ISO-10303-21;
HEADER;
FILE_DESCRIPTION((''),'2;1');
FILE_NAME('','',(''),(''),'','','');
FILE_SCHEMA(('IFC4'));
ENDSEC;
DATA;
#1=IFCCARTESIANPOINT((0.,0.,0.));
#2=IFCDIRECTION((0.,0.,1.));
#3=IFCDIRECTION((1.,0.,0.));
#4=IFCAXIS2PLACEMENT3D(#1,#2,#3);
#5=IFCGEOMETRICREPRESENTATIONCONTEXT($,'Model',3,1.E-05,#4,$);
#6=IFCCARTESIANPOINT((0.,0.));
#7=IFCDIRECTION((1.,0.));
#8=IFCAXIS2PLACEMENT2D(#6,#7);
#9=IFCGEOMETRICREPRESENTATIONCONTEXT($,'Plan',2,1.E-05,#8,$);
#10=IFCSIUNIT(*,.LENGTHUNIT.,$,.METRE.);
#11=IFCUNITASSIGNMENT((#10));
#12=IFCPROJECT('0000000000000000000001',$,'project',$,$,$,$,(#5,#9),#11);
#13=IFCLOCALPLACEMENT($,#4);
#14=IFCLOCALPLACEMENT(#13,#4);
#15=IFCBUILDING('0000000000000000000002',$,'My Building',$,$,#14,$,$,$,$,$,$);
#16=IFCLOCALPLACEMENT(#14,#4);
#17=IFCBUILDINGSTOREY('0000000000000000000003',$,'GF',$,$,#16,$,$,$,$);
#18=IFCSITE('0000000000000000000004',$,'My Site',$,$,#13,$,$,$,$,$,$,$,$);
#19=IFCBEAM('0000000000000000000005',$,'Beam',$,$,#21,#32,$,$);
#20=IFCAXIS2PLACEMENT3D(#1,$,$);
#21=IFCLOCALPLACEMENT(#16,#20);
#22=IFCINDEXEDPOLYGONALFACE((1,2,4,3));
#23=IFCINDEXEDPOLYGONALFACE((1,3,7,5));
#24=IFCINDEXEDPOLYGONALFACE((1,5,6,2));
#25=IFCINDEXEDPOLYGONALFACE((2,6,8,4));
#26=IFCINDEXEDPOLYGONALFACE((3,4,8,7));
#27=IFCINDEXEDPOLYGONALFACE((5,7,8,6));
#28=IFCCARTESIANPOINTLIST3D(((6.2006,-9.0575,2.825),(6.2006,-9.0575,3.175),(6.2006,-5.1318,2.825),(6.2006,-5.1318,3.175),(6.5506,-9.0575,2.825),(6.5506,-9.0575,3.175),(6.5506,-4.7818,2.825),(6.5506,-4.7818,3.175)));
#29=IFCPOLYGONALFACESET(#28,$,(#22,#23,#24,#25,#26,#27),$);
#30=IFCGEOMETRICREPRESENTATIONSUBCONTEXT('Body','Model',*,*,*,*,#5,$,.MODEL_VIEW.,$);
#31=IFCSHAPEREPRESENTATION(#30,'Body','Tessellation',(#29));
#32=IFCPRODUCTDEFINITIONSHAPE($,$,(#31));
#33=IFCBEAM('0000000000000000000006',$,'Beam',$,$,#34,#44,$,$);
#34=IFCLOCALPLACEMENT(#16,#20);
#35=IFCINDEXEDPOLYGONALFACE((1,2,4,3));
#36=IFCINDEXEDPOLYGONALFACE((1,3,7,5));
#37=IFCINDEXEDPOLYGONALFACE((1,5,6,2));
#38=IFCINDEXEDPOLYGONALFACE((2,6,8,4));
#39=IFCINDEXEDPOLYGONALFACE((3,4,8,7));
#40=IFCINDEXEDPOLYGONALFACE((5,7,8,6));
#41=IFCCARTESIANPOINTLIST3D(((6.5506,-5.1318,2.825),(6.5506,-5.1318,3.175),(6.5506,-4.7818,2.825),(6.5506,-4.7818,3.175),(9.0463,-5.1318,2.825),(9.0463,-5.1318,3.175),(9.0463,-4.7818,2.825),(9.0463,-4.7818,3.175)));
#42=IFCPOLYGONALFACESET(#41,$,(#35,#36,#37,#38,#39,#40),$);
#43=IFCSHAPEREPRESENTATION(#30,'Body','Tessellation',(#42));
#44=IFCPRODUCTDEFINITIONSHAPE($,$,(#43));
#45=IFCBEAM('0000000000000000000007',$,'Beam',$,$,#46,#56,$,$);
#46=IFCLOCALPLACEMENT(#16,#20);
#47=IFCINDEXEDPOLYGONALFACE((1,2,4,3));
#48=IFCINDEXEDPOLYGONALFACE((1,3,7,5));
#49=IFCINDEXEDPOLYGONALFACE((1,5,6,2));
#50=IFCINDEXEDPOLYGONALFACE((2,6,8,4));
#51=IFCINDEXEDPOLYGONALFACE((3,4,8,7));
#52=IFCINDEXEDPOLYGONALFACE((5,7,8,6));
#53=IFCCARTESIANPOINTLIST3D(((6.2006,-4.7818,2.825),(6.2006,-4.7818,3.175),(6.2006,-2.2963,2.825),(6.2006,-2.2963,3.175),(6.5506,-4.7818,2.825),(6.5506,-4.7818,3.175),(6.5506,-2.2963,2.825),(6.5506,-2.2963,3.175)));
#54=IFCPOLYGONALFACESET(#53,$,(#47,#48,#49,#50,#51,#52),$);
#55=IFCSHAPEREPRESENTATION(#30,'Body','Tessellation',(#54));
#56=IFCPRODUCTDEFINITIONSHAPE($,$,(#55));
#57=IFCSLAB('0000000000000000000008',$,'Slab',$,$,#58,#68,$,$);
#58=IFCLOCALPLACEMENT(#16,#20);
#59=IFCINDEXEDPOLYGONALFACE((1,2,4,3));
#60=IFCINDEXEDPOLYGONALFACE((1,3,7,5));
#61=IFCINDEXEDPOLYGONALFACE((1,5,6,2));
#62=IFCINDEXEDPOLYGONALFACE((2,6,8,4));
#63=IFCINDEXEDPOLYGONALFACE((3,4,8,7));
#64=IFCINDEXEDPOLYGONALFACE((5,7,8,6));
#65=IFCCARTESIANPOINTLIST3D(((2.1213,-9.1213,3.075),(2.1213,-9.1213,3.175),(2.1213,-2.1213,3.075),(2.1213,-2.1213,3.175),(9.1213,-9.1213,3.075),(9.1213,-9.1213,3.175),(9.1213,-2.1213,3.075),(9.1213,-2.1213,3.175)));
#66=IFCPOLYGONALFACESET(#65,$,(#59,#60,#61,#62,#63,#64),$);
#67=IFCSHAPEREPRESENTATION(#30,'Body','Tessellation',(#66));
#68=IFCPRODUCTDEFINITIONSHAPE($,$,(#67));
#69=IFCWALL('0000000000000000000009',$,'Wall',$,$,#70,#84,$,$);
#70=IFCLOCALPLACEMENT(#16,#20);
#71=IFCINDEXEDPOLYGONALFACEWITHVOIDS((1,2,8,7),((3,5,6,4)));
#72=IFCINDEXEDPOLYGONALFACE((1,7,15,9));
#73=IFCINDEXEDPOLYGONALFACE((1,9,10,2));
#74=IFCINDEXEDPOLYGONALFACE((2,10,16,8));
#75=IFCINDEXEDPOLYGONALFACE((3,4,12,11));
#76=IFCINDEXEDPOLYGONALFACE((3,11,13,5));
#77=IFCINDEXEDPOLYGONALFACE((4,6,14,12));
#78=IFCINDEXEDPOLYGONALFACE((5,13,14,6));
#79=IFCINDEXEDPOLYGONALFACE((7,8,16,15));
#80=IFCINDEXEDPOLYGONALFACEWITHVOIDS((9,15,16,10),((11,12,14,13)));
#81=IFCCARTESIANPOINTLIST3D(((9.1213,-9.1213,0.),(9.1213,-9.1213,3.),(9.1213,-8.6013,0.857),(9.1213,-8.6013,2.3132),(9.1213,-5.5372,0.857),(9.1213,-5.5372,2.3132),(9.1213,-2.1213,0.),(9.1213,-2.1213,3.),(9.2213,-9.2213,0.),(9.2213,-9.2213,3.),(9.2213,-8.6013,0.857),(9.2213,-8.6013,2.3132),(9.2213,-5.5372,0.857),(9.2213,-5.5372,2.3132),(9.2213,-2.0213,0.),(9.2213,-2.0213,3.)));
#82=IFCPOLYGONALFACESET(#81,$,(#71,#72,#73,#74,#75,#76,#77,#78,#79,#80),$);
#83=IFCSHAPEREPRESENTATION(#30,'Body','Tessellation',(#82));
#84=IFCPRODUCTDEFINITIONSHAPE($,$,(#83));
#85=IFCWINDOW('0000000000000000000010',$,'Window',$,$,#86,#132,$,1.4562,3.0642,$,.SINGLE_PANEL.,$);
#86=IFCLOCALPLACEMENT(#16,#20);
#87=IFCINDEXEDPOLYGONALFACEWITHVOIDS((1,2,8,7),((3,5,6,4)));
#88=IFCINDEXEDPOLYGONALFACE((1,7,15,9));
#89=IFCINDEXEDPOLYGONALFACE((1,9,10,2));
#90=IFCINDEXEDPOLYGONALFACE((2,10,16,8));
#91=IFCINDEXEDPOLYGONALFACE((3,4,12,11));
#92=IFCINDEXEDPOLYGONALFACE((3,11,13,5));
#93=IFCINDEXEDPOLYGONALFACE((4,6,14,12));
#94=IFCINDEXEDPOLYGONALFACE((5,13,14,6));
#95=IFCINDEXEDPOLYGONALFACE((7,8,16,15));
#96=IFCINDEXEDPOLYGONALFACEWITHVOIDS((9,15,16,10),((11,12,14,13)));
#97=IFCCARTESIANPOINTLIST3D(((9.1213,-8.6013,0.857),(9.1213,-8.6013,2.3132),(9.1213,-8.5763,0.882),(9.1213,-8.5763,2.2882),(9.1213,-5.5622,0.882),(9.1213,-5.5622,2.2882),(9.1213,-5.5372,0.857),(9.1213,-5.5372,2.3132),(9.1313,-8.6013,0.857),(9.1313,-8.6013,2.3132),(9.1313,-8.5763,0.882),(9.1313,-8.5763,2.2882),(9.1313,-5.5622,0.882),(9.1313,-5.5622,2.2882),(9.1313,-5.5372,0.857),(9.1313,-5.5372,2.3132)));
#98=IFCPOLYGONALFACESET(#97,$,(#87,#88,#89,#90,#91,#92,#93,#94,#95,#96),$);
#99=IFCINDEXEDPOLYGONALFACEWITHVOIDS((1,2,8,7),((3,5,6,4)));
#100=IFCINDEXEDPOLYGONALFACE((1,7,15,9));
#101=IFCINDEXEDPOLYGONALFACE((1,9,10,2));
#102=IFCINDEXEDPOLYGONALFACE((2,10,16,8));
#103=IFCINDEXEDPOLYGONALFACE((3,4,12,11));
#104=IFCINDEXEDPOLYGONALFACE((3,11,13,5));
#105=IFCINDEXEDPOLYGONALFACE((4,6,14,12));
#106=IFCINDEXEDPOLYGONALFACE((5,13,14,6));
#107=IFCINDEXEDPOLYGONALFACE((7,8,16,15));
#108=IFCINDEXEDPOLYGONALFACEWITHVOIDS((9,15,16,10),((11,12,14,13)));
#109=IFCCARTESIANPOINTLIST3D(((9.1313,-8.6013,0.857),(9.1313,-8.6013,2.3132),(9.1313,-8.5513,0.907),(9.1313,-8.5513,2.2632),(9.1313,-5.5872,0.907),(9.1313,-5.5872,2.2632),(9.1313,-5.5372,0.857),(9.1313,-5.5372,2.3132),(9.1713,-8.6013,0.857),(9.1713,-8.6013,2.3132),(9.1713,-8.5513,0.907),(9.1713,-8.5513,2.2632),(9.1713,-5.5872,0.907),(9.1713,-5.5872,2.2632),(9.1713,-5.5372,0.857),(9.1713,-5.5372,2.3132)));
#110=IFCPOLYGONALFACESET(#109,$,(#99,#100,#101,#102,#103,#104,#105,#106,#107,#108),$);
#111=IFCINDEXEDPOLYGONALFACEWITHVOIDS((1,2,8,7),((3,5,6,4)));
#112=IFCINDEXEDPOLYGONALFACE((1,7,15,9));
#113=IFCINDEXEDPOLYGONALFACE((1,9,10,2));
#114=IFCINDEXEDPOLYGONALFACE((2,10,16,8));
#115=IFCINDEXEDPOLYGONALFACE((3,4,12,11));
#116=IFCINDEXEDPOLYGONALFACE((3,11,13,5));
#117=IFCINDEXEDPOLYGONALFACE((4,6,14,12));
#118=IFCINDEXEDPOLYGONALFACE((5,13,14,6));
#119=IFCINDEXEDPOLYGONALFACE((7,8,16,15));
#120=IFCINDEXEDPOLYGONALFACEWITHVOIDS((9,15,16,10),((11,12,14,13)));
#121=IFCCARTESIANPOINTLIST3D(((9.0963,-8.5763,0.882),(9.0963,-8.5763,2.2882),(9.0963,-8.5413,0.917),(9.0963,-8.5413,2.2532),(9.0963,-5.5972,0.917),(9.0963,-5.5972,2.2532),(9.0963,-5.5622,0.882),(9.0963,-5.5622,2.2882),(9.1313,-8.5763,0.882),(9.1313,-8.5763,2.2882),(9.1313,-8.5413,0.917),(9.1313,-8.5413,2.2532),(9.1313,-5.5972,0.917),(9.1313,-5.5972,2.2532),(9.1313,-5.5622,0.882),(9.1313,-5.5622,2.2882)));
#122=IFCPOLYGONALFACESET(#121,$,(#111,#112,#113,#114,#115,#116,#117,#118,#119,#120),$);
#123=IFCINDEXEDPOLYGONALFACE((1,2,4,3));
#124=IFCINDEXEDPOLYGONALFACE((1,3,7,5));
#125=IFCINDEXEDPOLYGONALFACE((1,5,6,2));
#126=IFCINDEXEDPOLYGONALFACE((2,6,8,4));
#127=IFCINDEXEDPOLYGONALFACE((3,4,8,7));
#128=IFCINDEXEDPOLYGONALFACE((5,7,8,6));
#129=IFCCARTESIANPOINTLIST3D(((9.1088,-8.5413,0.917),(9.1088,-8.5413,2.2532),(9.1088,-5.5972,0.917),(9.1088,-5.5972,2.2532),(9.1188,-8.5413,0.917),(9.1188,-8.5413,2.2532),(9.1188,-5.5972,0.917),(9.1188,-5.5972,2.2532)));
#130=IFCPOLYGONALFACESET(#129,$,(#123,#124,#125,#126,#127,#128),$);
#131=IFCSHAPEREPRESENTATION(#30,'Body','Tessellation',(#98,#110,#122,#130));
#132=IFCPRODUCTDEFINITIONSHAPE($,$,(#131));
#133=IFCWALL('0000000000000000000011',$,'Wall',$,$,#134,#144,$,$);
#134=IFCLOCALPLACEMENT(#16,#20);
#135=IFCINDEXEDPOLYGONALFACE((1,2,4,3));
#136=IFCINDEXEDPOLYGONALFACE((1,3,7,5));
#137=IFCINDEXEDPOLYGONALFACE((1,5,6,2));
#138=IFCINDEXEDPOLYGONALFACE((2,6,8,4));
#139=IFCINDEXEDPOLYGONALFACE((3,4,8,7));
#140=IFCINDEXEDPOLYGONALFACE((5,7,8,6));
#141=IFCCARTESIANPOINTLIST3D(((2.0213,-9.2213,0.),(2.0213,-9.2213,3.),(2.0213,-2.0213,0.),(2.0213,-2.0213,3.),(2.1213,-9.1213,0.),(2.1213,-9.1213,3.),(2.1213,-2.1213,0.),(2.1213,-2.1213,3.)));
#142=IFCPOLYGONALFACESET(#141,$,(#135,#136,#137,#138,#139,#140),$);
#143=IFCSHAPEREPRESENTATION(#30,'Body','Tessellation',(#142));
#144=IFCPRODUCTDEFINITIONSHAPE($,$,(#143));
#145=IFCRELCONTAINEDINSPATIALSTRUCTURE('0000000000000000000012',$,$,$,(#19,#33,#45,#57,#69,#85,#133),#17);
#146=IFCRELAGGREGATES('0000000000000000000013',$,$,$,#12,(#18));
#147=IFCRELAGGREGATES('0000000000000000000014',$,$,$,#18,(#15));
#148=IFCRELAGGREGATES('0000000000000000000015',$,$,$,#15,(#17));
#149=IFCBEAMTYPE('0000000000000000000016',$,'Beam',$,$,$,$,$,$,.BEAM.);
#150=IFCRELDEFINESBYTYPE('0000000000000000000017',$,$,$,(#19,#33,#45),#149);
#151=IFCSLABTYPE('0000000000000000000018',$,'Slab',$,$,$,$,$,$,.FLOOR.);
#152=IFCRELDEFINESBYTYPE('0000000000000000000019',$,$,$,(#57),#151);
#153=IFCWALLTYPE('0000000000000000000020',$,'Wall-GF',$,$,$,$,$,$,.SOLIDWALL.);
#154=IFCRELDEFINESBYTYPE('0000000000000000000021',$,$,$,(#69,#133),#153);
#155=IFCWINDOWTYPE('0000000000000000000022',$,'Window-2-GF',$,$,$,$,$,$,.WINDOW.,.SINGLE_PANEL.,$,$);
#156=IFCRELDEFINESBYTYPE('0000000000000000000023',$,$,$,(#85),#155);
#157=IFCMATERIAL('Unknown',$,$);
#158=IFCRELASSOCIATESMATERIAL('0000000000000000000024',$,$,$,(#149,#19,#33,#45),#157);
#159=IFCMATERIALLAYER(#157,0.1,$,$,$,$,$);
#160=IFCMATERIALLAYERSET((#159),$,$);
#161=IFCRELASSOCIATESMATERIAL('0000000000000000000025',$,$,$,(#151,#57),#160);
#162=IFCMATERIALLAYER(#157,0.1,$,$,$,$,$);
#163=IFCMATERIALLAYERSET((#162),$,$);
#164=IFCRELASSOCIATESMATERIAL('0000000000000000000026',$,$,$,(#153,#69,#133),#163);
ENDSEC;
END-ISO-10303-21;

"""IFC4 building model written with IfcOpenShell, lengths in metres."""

from ifc_helpers import new_model, entity, si_unit, frame, origin_with_axes, origin_2d_with_axis, place, context, subcontext, project, spatial, line, indexed_curve, rectangle, outline, extrude, clip, halfspace, shape, source, transform, mapped, material, layer, layer_set, layer_usage, material_profile, profile_set, profile_usage, type_object, type_shapes, element, fill, save


model = new_model("IFC4")

# Units and contexts
model_context = context("Model", 3, precision=1e-05, world=origin_with_axes())
plan_context = context("Plan", 2, precision=1e-05, world=origin_2d_with_axis())
body_context_1 = subcontext(model_context, "Body", "Model", "MODEL_VIEW")
body_context_2 = subcontext(plan_context, "Body", "Plan", "PLAN_VIEW")
ifc_project = project(units=[si_unit("LENGTHUNIT", "METRE")], contexts=[model_context, plan_context])

# Site, building, storey
site_placement = place(None, origin_with_axes())
site = spatial("IfcSite", under=ifc_project, at=site_placement, Name="My Site")
building_placement = place(site_placement, origin_with_axes())
building = spatial("IfcBuilding", under=site, at=building_placement, Name="My Building")
storey_placement = place(building_placement, origin_with_axes())
storey = spatial("IfcBuildingStorey", under=building, at=storey_placement, Name="GF")

# Shared definitions
ifc_material = material(Name="Unknown")

# Beams
ifc_material_profile_1 = material_profile(ifc_material, rectangle(XDim=0.35, YDim=0.35))
ifc_profile_set_1 = profile_set([ifc_material_profile_1])
beam_type = type_object("IfcBeamType", Name="Beam", PredefinedType="BEAM", material=ifc_profile_set_1)
ifc_profile_usage_1 = profile_usage(ifc_profile_set_1, cardinal=5)
beam_1_placement = place(storey_placement, frame((6.3756, -4.7818, 3.0), z_axis=(0.0, -1.0, 0.0), x_axis=(1.0, 0.0, 0.0)))
element("IfcBeam", 1, at=beam_1_placement, inside=storey, type_object=beam_type, material=ifc_profile_usage_1, Name="Beam", context=body_context_1, shape_type="Clipping", body=[
    clip(extrude(rectangle(XDim=0.35, YDim=0.35), origin_with_axes(), (0.0, 0.0, 1.0), 4.2757), halfspace(frame((0.175, -3.0, 0.0), z_axis=(-0.707107, 0.0, -0.707107), x_axis=(0.0, 1.0, 0.0)), False)),
])
ifc_profile_usage_2 = profile_usage(ifc_profile_set_1, cardinal=5)
beam_2_placement = place(storey_placement, frame((6.5506, -4.9568, 3.0), z_axis=(1.0, 0.0, 0.0), x_axis=(0.0, 1.0, 0.0)))
element("IfcBeam", 2, at=beam_2_placement, inside=storey, type_object=beam_type, material=ifc_profile_usage_2, Name="Beam", context=body_context_1, shape_type="SweptSolid", body=[
    extrude(rectangle(XDim=0.35, YDim=0.35), origin_with_axes(), (0.0, 0.0, 1.0), 2.4957),
])
ifc_profile_usage_3 = profile_usage(ifc_profile_set_1, cardinal=5)
beam_3_placement = place(storey_placement, frame((6.3756, -4.7818, 3.0), z_axis=(0.0, 1.0, 0.0), x_axis=(-1.0, 0.0, 0.0)))
element("IfcBeam", 3, at=beam_3_placement, inside=storey, type_object=beam_type, material=ifc_profile_usage_3, Name="Beam", context=body_context_1, shape_type="SweptSolid", body=[
    extrude(rectangle(XDim=0.35, YDim=0.35), origin_with_axes(), (0.0, 0.0, 1.0), 2.4855),
])

# Slab
ifc_layer_1 = layer(ifc_material, 0.1)
ifc_layer_set_1 = layer_set([ifc_layer_1])
slab_type = type_object("IfcSlabType", Name="Slab", PredefinedType="FLOOR", material=ifc_layer_set_1)
ifc_layer_usage_1 = layer_usage(ifc_layer_set_1, "AXIS3", "POSITIVE", -0.1)
slab_1_placement = place(storey_placement, frame((2.1213, -2.1213, 3.175), z_axis=(0.0, 0.0, 1.0), x_axis=(1.0, 0.0, 0.0)))
element("IfcSlab", 4, at=slab_1_placement, inside=storey, type_object=slab_type, material=ifc_layer_usage_1, Name="Slab", context=body_context_1, shape_type="SweptSolid", body=[
    extrude(outline(indexed_curve([(0.0, 0.0), (7.0, 0.0), (7.0, -7.0), (0.0, -7.0), (0.0, 0.0)])), frame((0.0, 0.0, -0.1), z_axis=(0.0, 0.0, 1.0), x_axis=(1.0, 0.0, 0.0)), (0.0, 0.0, 1.0), 0.1),
])

# Wall, opening, window
ifc_layer_2 = layer(ifc_material, 0.1)
ifc_layer_set_2 = layer_set([ifc_layer_2])
ifc_layer_usage_2 = layer_usage(ifc_layer_set_2, "AXIS2", "POSITIVE", 0.0)
wall_type = type_object("IfcWallType", Name="Wall-GF", PredefinedType="SOLIDWALL", material=ifc_layer_set_2)
wall_1_placement = place(storey_placement, frame((9.1213, -2.1213, 0.0), z_axis=(0.0, 0.0, 1.0), x_axis=(0.0, -1.0, 0.0)))
wall_1 = element("IfcWall", 5, at=wall_1_placement, inside=storey, type_object=wall_type, material=ifc_layer_usage_2, Name="Wall", context=body_context_1, shape_type="SweptSolid", body=[
    extrude(outline(indexed_curve([(0.0, 0.0), (-0.1, 0.1), (7.1, 0.1), (7.0, 0.0)], segments=[line(1, 2, 3, 4, 1)])), origin_with_axes(), (0.0, 0.0, 1.0), 3.0),
])
shared_shape_1 = source(origin_with_axes(), body_context_1, "Body", "SweptSolid", [
    extrude(outline(indexed_curve([(0.0, 0.0), (3.0642, 0.0), (3.0642, 1.4562), (0.0, 1.4562)], segments=[line(1, 2, 3, 4, 1)])), frame((0.0, -0.6, 0.0), z_axis=(0.0, -1.0, 0.0), x_axis=(1.0, 0.0, 0.0)), (0.0, 0.0, -1.0), 1.2),
])
opening_1_placement = place(wall_1_placement, frame((6.48, 0.1, 0.857), z_axis=(0.0, 0.0, 1.0), x_axis=(-1.0, 0.0, 0.0)))
opening_1 = element("IfcOpeningElement", 6, at=opening_1_placement, cuts=wall_1, PredefinedType="OPENING", context=body_context_1, shape_type="MappedRepresentation", body=[
    mapped(shared_shape_1, transform((0.0, 0.0, 0.0), x_axis=(1.0, 0.0, 0.0), y_axis=(0.0, 1.0, 0.0), z_axis=(0.0, 0.0, 1.0), scale=1.0)),
])
window_type_1 = type_object("IfcWindowType", Name="Window-2-GF", PartitioningType="SINGLE_PANEL", PredefinedType="WINDOW")
shared_shape_2 = source(origin_with_axes(), body_context_1, "Body", "SweptSolid", [
    extrude(outline(indexed_curve([(0.0, 0.0), (3.0642, 0.0), (3.0642, 1.4562), (0.0, 1.4562)], segments=[line(1, 2, 3, 4, 1)]), holes=[indexed_curve([(0.025, 0.025), (3.0392, 0.025), (3.0392, 1.4312), (0.025, 1.4312)], segments=[line(1, 2, 3, 4, 1)])]), frame((0.0, 0.09, 0.0), z_axis=(0.0, -1.0, 0.0), x_axis=(1.0, 0.0, 0.0)), (0.0, 0.0, -1.0), 0.01),
    extrude(outline(indexed_curve([(0.0, 0.0), (3.0642, 0.0), (3.0642, 1.4562), (0.0, 1.4562)], segments=[line(1, 2, 3, 4, 1)]), holes=[indexed_curve([(0.05, 0.05), (3.0142, 0.05), (3.0142, 1.4062), (0.05, 1.4062)], segments=[line(1, 2, 3, 4, 1)])]), frame((0.0, 0.05, 0.0), z_axis=(0.0, -1.0, 0.0), x_axis=(1.0, 0.0, 0.0)), (0.0, 0.0, -1.0), 0.04),
    extrude(outline(indexed_curve([(0.0, 0.0), (3.0142, 0.0), (3.0142, 1.4062), (0.0, 1.4062)], segments=[line(1, 2, 3, 4, 1)]), holes=[indexed_curve([(0.035, 0.035), (2.9792, 0.035), (2.9792, 1.3712), (0.035, 1.3712)], segments=[line(1, 2, 3, 4, 1)])]), frame((0.025, 0.09, 0.025), z_axis=(0.0, -1.0, 0.0), x_axis=(1.0, 0.0, 0.0)), (0.0, 0.0, -1.0), 0.035),
    extrude(outline(indexed_curve([(0.035, 0.035), (2.9792, 0.035), (2.9792, 1.3712), (0.035, 1.3712)], segments=[line(1, 2, 3, 4, 1)])), frame((0.025, 0.1025, 0.025), z_axis=(0.0, -1.0, 0.0), x_axis=(1.0, 0.0, 0.0)), (0.0, 0.0, -1.0), 0.01),
])
shared_shape_3 = source(origin_with_axes(), body_context_2, "Body", "Curve2D", [
    entity("IfcIndexedPolyCurve", entity("IfcCartesianPointList2D", [[0.05, 0.05], [3.0142, 0.05]])),
    entity("IfcIndexedPolyCurve", entity("IfcCartesianPointList2D", [[0.0, 0.1], [0.025, 0.1], [0.025, 0.09], [0.05, 0.09], [0.05, 0.05], [0.0, 0.05]]), [entity("IfcLineIndex", [1, 2, 3, 4, 5, 6, 1])]),
    entity("IfcIndexedPolyCurve", entity("IfcCartesianPointList2D", [[3.0642, 0.1], [3.0392, 0.1], [3.0392, 0.09], [3.0142, 0.09], [3.0142, 0.05], [3.0642, 0.05]]), [entity("IfcLineIndex", [1, 2, 3, 4, 5, 6, 1])]),
    entity("IfcIndexedPolyCurve", entity("IfcCartesianPointList2D", [[0.025, 0.09], [0.06, 0.09], [0.06, 0.125], [0.025, 0.125]]), [entity("IfcLineIndex", [1, 2, 3, 4, 1])]),
    entity("IfcIndexedPolyCurve", entity("IfcCartesianPointList2D", [[3.0392, 0.09], [3.0042, 0.09], [3.0042, 0.125], [3.0392, 0.125]]), [entity("IfcLineIndex", [1, 2, 3, 4, 1])]),
    entity("IfcIndexedPolyCurve", entity("IfcCartesianPointList2D", [[0.06, 0.09], [3.0042, 0.09]])),
    entity("IfcIndexedPolyCurve", entity("IfcCartesianPointList2D", [[0.06, 0.125], [3.0042, 0.125]])),
    entity("IfcIndexedPolyCurve", entity("IfcCartesianPointList2D", [[0.06, 0.1075], [3.0042, 0.1075]])),
])
type_shapes(window_type_1, [shared_shape_2, shared_shape_3])
window_1_placement = place(opening_1_placement, frame((0.0, 0.0, 0.0), z_axis=(0.0, 0.0, 1.0), x_axis=(1.0, 0.0, 0.0)))
window_1 = element("IfcWindow", 7, at=window_1_placement, inside=storey, type_object=window_type_1, Name="Window", OverallHeight=1.4562, OverallWidth=3.0642, PartitioningType="SINGLE_PANEL", shapes=[
    shape(body_context_1, "Body", "MappedRepresentation", [mapped(shared_shape_2, transform((0.0, 0.0, 0.0), x_axis=(1.0, 0.0, 0.0), y_axis=(0.0, 1.0, 0.0), z_axis=(0.0, 0.0, 1.0), scale=1.0))]),
    shape(body_context_2, "Body", "MappedRepresentation", [mapped(shared_shape_3, transform((0.0, 0.0, 0.0), x_axis=(1.0, 0.0, 0.0), y_axis=(0.0, 1.0, 0.0), z_axis=(0.0, 0.0, 1.0), scale=1.0))]),
])
fill(opening_1, window_1)

# Wall
ifc_layer_usage_3 = layer_usage(ifc_layer_set_2, "AXIS2", "POSITIVE", 0.0)
wall_2_placement = place(storey_placement, frame((2.1213, -9.1213, 0.0), z_axis=(0.0, 0.0, 1.0), x_axis=(-0.000003, 1.0, 0.0)))
element("IfcWall", 8, at=wall_2_placement, inside=storey, type_object=wall_type, material=ifc_layer_usage_3, Name="Wall", context=body_context_1, shape_type="SweptSolid", body=[
    extrude(outline(indexed_curve([(0.0, 0.0), (-0.1, 0.1), (7.1, 0.1), (7.0, 0.0)], segments=[line(1, 2, 3, 4, 1)])), origin_with_axes(), (0.0, 0.0, 1.0), 3.0),
])

save(model, "model.ifc")
